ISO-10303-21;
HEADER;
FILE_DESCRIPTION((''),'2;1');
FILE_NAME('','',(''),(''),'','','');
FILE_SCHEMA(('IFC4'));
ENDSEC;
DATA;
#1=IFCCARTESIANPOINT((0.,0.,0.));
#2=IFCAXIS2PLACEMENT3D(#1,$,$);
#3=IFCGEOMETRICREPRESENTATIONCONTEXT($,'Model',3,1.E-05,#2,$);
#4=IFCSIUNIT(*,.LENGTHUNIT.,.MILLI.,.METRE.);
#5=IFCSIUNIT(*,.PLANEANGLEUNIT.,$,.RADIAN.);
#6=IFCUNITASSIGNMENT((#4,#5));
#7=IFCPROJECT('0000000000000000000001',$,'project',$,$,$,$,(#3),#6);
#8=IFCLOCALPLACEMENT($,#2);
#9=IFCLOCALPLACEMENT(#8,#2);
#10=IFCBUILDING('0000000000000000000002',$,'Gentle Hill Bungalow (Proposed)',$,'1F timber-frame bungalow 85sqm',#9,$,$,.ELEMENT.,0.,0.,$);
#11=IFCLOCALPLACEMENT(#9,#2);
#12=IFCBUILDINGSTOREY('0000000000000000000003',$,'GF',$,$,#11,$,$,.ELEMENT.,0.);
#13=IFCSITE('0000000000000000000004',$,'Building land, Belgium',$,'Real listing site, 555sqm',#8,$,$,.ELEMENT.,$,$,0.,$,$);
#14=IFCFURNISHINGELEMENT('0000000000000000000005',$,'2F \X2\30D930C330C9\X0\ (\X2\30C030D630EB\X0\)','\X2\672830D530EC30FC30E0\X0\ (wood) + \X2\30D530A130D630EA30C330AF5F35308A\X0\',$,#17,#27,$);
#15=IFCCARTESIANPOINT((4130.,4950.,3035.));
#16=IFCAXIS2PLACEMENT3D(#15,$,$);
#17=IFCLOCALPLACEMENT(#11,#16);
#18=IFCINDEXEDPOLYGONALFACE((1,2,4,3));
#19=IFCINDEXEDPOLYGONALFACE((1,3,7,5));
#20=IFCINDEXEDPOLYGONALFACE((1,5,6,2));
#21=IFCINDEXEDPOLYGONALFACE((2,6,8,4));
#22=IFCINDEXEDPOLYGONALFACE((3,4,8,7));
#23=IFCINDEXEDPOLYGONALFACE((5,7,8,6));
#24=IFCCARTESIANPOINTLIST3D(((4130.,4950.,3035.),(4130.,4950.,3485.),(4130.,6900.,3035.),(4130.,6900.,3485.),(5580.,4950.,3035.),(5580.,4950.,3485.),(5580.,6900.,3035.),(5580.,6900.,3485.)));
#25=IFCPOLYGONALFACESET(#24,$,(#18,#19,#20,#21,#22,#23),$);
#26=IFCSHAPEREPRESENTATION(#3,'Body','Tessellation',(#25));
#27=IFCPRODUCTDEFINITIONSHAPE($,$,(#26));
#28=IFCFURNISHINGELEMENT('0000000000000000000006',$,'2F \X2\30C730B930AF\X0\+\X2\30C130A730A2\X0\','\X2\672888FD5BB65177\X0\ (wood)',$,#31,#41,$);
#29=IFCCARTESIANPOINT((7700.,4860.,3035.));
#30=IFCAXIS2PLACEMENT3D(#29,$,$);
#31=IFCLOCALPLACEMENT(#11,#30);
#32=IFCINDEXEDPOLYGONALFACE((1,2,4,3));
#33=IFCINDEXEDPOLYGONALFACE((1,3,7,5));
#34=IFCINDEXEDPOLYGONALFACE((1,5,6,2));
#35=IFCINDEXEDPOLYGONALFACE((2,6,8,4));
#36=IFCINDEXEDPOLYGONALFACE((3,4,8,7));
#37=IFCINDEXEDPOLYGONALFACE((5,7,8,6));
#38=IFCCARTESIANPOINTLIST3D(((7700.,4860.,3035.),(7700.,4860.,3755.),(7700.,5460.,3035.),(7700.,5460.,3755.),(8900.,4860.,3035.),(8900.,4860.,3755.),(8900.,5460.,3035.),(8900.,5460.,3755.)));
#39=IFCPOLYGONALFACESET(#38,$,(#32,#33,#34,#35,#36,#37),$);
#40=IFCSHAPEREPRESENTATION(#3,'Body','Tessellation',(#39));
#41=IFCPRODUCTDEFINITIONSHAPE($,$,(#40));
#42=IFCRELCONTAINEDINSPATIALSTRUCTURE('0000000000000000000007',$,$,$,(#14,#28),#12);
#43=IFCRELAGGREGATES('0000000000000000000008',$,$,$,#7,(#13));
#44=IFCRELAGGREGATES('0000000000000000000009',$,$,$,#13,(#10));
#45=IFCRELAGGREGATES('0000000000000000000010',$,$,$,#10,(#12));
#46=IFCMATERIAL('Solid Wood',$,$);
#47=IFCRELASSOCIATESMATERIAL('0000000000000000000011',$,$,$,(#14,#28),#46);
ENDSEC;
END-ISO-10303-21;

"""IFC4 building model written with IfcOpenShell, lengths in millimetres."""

from ifc_helpers import new_model, si_unit, frame, frame_2d, origin, place, context, project, spatial, rectangle, extrude, material, element, save


model = new_model("IFC4")

# Units and contexts
model_context = context("Model", 3, precision=1e-05, world=origin())
ifc_project = project(units=[si_unit("LENGTHUNIT", "METRE", prefix="MILLI"), si_unit("PLANEANGLEUNIT", "RADIAN")], contexts=[model_context])

# Site, building, storey
site_placement = place(None, origin())
site = spatial("IfcSite", under=ifc_project, at=site_placement, Name="Building land, Belgium", ObjectType="Real listing site, 555sqm", CompositionType="ELEMENT", RefElevation=0.0)
building_placement = place(site_placement, origin())
building = spatial("IfcBuilding", under=site, at=building_placement, Name="Gentle Hill Bungalow (Proposed)", ObjectType="1F timber-frame bungalow 85sqm", CompositionType="ELEMENT", ElevationOfRefHeight=0.0, ElevationOfTerrain=0.0)
storey_placement = place(building_placement, origin())
storey = spatial("IfcBuildingStorey", under=building, at=storey_placement, Name="GF", CompositionType="ELEMENT", Elevation=0.0)

# Shared definitions
ifc_material_1 = material(Name="Solid Wood")

# Furnishing elements
furnishing_1_placement = place(storey_placement, frame((4130.0, 4950.0, 3035.0)))
element("IfcFurnishingElement", 1, at=furnishing_1_placement, inside=storey, material=ifc_material_1, Name="2F ベッド (ダブル)", Description="木フレーム (wood) + ファブリック張り", context=model_context, shape_type="SweptSolid", body=[
    extrude(rectangle(XDim=1450.0, YDim=1950.0, at=frame_2d((725.0, 975.0))), frame((4130.0, 4950.0, 3035.0)), (0.0, 0.0, 1.0), 450.0),
])
furnishing_2_placement = place(storey_placement, frame((7700.0, 4860.0, 3035.0)))
element("IfcFurnishingElement", 2, at=furnishing_2_placement, inside=storey, material=ifc_material_1, Name="2F デスク+チェア", Description="木製家具 (wood)", context=model_context, shape_type="SweptSolid", body=[
    extrude(rectangle(XDim=1200.0, YDim=600.0, at=frame_2d((600.0, 300.0))), frame((7700.0, 4860.0, 3035.0)), (0.0, 0.0, 1.0), 720.0),
])

save(model, "model.ifc")
